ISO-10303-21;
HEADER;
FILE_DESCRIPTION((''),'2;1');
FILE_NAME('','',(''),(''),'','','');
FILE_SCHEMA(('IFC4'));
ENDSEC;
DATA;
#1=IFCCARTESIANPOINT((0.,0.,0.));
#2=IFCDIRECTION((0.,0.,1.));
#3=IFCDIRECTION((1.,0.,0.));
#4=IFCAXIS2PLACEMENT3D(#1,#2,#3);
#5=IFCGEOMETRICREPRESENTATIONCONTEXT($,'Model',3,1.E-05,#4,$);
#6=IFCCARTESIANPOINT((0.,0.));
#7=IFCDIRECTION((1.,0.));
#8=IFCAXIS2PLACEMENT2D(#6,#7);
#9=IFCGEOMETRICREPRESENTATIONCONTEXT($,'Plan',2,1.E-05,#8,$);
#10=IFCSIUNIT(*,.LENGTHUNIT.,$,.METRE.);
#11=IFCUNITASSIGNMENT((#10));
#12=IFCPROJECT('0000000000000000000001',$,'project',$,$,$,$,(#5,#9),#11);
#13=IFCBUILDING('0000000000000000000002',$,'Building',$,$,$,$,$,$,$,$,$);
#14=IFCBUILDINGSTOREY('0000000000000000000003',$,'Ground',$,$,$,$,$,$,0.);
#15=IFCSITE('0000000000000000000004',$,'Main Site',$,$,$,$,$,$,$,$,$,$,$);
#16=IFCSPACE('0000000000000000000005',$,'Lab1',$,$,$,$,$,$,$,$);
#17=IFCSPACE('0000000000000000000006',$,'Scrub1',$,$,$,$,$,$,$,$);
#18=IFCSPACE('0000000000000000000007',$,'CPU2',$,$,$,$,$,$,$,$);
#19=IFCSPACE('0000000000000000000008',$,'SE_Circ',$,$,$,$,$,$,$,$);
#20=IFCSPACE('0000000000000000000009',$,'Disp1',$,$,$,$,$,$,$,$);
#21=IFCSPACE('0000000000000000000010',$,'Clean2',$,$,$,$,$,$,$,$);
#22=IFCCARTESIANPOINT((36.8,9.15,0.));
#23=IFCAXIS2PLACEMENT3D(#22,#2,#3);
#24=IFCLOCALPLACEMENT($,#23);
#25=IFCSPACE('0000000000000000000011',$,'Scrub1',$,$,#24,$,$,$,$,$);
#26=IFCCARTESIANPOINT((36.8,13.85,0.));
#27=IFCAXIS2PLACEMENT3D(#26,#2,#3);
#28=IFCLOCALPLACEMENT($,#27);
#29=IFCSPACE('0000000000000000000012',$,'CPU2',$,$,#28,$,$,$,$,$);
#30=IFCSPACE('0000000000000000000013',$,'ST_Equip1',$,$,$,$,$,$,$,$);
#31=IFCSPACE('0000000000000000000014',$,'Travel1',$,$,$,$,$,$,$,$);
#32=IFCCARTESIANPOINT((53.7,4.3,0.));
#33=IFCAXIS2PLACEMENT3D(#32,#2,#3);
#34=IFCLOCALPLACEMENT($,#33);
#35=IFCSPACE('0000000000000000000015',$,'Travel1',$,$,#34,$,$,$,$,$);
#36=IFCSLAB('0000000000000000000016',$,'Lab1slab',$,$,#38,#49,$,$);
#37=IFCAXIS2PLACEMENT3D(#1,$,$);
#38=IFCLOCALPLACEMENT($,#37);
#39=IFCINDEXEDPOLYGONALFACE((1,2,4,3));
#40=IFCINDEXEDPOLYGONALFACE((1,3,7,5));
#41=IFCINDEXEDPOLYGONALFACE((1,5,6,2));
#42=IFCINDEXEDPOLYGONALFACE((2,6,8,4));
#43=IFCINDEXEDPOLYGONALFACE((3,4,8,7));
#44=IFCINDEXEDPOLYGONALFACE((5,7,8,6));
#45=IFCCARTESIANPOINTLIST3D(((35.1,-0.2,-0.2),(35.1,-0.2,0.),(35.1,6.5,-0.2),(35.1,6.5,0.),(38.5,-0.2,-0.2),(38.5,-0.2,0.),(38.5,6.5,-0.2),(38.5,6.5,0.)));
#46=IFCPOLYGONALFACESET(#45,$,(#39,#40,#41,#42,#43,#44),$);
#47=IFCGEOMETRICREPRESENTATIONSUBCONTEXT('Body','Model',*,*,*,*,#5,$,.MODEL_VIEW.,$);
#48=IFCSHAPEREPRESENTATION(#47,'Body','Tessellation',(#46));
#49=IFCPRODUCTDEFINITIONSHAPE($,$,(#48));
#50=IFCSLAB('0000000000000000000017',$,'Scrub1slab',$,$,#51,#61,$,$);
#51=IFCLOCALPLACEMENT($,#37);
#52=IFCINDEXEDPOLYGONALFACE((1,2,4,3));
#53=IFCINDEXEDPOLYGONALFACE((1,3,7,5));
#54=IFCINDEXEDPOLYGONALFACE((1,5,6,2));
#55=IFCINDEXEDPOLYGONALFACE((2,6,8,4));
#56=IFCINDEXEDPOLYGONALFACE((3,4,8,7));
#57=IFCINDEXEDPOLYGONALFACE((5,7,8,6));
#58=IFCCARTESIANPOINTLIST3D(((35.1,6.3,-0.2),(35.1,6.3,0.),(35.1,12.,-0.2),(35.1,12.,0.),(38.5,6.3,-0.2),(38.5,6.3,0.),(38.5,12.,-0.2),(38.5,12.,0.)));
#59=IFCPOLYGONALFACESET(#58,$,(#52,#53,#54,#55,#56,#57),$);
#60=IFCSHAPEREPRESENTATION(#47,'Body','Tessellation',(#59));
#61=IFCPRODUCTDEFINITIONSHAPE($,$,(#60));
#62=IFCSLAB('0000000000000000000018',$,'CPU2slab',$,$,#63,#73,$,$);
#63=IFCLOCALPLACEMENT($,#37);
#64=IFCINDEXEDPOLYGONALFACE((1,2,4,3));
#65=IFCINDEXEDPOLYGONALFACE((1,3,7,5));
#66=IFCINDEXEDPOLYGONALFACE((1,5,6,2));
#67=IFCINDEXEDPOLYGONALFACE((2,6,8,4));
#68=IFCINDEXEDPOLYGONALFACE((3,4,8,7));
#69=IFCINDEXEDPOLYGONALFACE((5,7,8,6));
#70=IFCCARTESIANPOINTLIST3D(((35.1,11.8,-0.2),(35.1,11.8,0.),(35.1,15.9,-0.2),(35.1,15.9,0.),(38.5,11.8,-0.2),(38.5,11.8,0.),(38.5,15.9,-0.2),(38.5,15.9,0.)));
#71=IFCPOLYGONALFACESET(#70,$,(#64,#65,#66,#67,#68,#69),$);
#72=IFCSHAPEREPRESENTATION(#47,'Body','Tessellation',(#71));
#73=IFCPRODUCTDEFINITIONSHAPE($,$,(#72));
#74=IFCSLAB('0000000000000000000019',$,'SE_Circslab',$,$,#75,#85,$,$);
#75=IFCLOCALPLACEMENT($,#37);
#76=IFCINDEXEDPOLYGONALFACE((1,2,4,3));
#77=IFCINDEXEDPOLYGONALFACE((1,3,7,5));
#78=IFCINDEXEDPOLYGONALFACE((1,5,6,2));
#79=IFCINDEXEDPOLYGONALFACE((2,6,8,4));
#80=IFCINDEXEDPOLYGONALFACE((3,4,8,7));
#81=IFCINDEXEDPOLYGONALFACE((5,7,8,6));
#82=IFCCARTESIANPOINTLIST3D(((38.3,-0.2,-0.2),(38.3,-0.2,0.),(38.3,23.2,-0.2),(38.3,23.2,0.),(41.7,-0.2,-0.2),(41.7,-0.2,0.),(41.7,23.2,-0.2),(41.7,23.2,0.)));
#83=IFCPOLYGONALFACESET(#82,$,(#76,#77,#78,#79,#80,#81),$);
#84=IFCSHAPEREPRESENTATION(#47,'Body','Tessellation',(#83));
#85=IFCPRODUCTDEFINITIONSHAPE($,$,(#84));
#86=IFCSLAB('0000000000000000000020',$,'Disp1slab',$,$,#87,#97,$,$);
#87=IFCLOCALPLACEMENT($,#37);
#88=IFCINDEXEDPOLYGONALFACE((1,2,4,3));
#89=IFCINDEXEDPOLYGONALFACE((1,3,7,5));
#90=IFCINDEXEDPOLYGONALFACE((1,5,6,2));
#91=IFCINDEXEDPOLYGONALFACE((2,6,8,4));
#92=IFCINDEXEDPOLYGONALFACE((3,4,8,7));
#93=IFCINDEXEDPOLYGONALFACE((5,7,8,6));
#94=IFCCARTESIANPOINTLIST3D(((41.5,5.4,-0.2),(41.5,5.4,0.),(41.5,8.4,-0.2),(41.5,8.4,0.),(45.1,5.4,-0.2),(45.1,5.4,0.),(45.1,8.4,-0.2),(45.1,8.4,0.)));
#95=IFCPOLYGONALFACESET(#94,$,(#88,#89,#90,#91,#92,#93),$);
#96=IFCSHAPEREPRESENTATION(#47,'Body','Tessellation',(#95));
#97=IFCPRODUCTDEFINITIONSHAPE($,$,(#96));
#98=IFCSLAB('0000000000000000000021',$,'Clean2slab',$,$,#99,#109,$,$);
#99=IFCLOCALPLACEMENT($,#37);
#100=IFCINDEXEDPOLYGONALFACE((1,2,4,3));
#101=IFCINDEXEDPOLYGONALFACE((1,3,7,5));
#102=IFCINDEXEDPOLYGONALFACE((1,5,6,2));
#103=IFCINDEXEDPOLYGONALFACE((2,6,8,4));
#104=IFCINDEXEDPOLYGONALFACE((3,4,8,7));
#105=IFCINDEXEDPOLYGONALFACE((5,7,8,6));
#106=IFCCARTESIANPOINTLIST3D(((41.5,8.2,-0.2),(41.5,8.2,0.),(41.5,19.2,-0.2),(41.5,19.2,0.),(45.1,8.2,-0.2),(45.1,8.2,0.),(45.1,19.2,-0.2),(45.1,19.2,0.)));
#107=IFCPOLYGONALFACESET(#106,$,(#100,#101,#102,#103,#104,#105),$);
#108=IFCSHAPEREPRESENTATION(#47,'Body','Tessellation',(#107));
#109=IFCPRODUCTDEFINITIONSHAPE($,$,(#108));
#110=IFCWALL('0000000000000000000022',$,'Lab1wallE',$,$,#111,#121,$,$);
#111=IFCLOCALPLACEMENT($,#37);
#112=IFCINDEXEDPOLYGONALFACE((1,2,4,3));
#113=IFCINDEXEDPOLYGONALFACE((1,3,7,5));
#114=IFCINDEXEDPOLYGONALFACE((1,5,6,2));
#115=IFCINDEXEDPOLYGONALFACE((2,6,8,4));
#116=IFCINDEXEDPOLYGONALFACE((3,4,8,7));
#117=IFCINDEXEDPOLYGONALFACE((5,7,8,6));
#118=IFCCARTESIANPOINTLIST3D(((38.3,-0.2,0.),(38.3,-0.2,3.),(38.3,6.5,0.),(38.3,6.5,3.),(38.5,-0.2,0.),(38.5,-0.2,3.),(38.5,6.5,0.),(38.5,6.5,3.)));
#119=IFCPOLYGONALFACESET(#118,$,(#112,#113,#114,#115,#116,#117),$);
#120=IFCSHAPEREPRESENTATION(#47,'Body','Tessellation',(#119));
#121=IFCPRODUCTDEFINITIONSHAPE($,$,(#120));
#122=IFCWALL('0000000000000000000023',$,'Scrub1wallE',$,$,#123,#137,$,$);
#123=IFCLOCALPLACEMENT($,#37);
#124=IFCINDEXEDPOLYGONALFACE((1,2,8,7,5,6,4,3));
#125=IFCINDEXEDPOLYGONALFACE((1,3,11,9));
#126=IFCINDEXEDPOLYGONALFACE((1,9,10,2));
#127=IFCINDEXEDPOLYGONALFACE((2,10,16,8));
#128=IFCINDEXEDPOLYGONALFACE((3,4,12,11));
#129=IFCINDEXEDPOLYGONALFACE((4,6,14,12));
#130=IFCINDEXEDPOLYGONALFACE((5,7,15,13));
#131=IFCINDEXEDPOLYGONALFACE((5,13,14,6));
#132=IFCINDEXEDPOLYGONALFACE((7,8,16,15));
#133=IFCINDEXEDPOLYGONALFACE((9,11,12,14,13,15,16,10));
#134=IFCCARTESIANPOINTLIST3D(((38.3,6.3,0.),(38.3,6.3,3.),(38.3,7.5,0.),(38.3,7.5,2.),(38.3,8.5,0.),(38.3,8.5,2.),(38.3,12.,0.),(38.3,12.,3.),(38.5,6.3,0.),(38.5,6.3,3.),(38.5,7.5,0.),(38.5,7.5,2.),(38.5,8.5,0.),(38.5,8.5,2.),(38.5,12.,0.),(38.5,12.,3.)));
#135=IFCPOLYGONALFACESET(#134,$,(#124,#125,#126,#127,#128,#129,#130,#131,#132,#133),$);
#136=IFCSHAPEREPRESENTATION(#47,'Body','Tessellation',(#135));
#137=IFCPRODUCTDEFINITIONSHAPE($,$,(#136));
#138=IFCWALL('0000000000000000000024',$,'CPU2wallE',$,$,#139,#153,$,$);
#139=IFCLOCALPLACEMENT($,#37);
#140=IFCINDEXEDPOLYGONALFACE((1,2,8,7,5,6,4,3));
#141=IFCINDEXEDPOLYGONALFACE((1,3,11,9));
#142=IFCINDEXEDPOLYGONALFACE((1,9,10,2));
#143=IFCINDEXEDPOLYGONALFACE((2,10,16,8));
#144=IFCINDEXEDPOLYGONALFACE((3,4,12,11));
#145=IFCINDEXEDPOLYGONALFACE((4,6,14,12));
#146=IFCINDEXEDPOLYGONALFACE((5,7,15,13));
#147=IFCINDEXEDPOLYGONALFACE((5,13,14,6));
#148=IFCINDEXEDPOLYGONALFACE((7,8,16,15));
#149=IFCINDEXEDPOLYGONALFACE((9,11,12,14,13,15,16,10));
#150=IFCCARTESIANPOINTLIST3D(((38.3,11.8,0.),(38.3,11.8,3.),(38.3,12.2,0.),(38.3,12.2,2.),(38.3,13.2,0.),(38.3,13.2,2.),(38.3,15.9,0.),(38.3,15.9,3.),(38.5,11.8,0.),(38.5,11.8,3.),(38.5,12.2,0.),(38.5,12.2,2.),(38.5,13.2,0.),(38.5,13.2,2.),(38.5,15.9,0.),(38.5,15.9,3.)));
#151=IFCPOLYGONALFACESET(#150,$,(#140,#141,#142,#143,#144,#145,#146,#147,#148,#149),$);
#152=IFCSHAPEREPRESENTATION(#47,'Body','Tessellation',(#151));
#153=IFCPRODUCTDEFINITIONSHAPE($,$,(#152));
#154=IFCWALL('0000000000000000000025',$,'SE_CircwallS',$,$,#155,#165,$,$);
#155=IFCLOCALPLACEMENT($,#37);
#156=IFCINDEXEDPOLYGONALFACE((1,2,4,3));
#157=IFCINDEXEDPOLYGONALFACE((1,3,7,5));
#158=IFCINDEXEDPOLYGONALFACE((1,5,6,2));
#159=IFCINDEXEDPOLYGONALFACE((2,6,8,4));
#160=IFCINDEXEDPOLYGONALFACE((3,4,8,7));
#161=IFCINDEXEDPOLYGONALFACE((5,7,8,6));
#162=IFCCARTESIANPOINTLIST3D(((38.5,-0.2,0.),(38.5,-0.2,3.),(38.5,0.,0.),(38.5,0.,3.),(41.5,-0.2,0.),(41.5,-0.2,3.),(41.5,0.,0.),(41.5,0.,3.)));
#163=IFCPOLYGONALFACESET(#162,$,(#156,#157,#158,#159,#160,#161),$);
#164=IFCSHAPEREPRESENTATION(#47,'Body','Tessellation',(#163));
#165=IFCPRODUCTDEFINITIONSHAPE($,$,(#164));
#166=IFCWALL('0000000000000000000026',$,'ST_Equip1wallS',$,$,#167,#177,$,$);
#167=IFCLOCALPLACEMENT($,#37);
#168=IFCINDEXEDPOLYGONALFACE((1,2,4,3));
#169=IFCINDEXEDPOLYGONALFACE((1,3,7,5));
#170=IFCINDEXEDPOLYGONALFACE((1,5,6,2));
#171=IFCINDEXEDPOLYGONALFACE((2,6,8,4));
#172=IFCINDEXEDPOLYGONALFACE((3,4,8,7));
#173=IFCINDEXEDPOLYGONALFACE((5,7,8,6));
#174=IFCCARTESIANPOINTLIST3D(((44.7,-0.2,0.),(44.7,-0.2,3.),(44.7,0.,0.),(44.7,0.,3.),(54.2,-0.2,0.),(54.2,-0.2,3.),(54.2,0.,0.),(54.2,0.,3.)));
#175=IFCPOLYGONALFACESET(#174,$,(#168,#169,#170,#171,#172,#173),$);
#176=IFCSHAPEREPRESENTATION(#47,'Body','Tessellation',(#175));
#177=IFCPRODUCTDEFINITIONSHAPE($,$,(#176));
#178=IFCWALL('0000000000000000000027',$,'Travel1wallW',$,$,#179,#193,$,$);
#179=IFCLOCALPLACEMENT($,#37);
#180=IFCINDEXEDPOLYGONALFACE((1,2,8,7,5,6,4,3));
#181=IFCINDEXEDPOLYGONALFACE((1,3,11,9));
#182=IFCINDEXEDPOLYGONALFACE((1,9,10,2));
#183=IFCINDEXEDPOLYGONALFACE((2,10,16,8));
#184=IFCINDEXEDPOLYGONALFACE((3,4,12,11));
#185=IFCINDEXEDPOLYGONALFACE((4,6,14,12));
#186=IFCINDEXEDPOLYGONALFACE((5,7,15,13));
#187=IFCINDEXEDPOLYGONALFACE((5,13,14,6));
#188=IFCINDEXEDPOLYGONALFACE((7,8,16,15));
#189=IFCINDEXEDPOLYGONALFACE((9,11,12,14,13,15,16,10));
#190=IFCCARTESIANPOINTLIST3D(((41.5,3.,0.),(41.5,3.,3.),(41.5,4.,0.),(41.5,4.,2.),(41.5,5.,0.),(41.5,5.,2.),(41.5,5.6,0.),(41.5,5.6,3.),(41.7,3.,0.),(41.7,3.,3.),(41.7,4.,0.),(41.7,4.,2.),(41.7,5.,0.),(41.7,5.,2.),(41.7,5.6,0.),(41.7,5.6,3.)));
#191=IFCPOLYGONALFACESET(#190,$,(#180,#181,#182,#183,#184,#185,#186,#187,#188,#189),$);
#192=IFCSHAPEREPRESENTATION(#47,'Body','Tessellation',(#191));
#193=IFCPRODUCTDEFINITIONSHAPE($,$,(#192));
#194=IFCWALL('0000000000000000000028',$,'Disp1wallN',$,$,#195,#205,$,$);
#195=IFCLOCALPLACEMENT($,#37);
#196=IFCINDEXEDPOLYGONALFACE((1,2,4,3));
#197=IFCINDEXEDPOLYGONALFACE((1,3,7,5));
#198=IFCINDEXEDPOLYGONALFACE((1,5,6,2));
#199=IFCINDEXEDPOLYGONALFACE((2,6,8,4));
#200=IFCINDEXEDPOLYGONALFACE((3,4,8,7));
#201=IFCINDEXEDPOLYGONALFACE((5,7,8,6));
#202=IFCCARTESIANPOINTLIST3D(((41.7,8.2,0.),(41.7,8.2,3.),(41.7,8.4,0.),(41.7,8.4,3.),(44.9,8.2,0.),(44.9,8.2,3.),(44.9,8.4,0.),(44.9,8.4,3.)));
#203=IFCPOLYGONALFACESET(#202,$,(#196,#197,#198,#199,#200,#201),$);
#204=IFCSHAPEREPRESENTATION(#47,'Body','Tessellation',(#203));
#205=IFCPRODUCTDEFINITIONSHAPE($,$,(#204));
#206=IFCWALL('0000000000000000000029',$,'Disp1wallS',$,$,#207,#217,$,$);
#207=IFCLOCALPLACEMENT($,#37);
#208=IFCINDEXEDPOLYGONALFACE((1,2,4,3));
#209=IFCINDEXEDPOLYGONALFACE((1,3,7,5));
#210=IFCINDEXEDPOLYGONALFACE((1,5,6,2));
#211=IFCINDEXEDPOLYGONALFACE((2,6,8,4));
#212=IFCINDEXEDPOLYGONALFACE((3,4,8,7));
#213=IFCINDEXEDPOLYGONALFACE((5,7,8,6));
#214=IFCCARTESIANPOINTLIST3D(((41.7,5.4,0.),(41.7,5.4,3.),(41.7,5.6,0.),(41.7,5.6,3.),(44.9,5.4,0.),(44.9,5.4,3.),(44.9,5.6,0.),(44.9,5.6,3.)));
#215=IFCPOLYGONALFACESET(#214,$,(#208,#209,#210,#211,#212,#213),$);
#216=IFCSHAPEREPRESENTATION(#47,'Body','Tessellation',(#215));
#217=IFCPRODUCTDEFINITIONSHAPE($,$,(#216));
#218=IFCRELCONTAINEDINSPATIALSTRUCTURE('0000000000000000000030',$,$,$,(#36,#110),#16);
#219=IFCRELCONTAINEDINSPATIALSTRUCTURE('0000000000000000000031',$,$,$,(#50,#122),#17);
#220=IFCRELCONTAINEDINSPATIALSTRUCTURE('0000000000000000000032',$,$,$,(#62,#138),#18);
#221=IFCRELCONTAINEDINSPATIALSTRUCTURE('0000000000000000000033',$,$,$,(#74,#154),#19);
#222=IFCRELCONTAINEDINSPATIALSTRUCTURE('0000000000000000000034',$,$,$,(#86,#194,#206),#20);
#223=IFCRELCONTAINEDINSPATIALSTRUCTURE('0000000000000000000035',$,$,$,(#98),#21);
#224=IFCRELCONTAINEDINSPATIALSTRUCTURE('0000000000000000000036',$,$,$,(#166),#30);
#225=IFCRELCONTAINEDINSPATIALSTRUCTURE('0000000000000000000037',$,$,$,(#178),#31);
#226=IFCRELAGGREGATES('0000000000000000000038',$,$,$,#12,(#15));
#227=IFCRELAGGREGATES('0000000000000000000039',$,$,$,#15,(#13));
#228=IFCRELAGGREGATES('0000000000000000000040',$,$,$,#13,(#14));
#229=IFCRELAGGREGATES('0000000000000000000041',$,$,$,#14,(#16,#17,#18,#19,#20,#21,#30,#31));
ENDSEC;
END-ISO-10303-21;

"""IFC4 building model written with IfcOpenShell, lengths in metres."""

from ifc_helpers import new_model, si_unit, frame, origin_with_axes, origin_2d_with_axis, place, context, subcontext, project, spatial, indexed_curve, rectangle, outline, extrude, element, save


model = new_model("IFC4")

# Units and contexts
model_context = context("Model", 3, precision=1e-05, world=origin_with_axes())
plan_context = context("Plan", 2, precision=1e-05, world=origin_2d_with_axis())
body_context = subcontext(model_context, "Body", "Model", "MODEL_VIEW")
ifc_project = project(units=[si_unit("LENGTHUNIT", "METRE")], contexts=[model_context, plan_context])

# Site, building, storey, space
site = spatial("IfcSite", under=ifc_project, Name="Main Site")
building = spatial("IfcBuilding", under=site, Name="Building")
storey = spatial("IfcBuildingStorey", under=building, Name="Ground", Elevation=0.0)
space_1 = spatial("IfcSpace", under=storey, Name="Lab1")

# Slab
slab_1_placement = place(None, frame((36.8, 3.15, -0.2), z_axis=(0.0, 0.0, 1.0), x_axis=(1.0, 0.0, 0.0)))
element("IfcSlab", 1, at=slab_1_placement, inside=space_1, Name="Lab1slab", context=body_context, shape_type="SweptSolid", body=[
    extrude(rectangle(XDim=3.4, YDim=6.7), origin_with_axes(), (0.0, 0.0, 1.0), 0.2),
])

# Shared definitions
space_2 = spatial("IfcSpace", under=storey, Name="Scrub1")

# Slab
slab_2_placement = place(None, frame((36.8, 9.15, -0.2), z_axis=(0.0, 0.0, 1.0), x_axis=(1.0, 0.0, 0.0)))
element("IfcSlab", 2, at=slab_2_placement, inside=space_2, Name="Scrub1slab", context=body_context, shape_type="SweptSolid", body=[
    extrude(rectangle(XDim=3.4, YDim=5.7), origin_with_axes(), (0.0, 0.0, 1.0), 0.2),
])

# Shared definitions
space_3 = spatial("IfcSpace", under=storey, Name="CPU2")

# Slab
slab_3_placement = place(None, frame((36.8, 13.85, -0.2), z_axis=(0.0, 0.0, 1.0), x_axis=(1.0, 0.0, 0.0)))
element("IfcSlab", 3, at=slab_3_placement, inside=space_3, Name="CPU2slab", context=body_context, shape_type="SweptSolid", body=[
    extrude(rectangle(XDim=3.4, YDim=4.1), origin_with_axes(), (0.0, 0.0, 1.0), 0.2),
])

# Shared definitions
space_4 = spatial("IfcSpace", under=storey, Name="SE_Circ")

# Slab
slab_4_placement = place(None, frame((40.0, 11.5, -0.2), z_axis=(0.0, 0.0, 1.0), x_axis=(1.0, 0.0, 0.0)))
element("IfcSlab", 4, at=slab_4_placement, inside=space_4, Name="SE_Circslab", context=body_context, shape_type="SweptSolid", body=[
    extrude(rectangle(XDim=3.4, YDim=23.4), origin_with_axes(), (0.0, 0.0, 1.0), 0.2),
])

# Shared definitions
space_5 = spatial("IfcSpace", under=storey, Name="Disp1")

# Slab
slab_5_placement = place(None, frame((43.3, 6.9, -0.2), z_axis=(0.0, 0.0, 1.0), x_axis=(1.0, 0.0, 0.0)))
element("IfcSlab", 5, at=slab_5_placement, inside=space_5, Name="Disp1slab", context=body_context, shape_type="SweptSolid", body=[
    extrude(rectangle(XDim=3.6, YDim=3.0), origin_with_axes(), (0.0, 0.0, 1.0), 0.2),
])

# Shared definitions
space_6 = spatial("IfcSpace", under=storey, Name="Clean2")

# Slab
slab_6_placement = place(None, frame((43.3, 13.7, -0.2), z_axis=(0.0, 0.0, 1.0), x_axis=(1.0, 0.0, 0.0)))
element("IfcSlab", 6, at=slab_6_placement, inside=space_6, Name="Clean2slab", context=body_context, shape_type="SweptSolid", body=[
    extrude(rectangle(XDim=3.6, YDim=11.0), origin_with_axes(), (0.0, 0.0, 1.0), 0.2),
])

# Walls
wall_1_placement = place(None, frame((38.5, -0.2, 0.0), z_axis=(0.0, 0.0, 1.0), x_axis=(0.0, 1.0, 0.0)))
element("IfcWall", 7, at=wall_1_placement, inside=space_1, Name="Lab1wallE", context=body_context, shape_type="SweptSolid", body=[
    extrude(outline(indexed_curve([(0.0, 0.0), (0.0, 0.2), (6.7, 0.2), (6.7, 0.0), (0.0, 0.0)], self_intersect=False)), origin_with_axes(), (0.0, 0.0, 1.0), 3.0),
])
wall_2_placement = place(None, frame((38.5, 6.3, 0.0), z_axis=(0.0, 0.0, 1.0), x_axis=(0.0, 1.0, 0.0)))
wall_2 = element("IfcWall", 8, at=wall_2_placement, inside=space_2, Name="Scrub1wallE", context=body_context, shape_type="SweptSolid", body=[
    extrude(outline(indexed_curve([(0.0, 0.0), (0.0, 0.2), (5.7, 0.2), (5.7, 0.0), (0.0, 0.0)], self_intersect=False)), origin_with_axes(), (0.0, 0.0, 1.0), 3.0),
])

# Shared definitions
space_7_placement = place(None, frame((36.8, 9.15, 0.0), z_axis=(0.0, 0.0, 1.0), x_axis=(1.0, 0.0, 0.0)))
space_7 = spatial("IfcSpace", at=space_7_placement, Name="Scrub1")

# Opening
opening_1_placement = place(wall_2_placement, frame((1.2, 0.0, 0.0), z_axis=(0.0, 0.0, 1.0), x_axis=(1.0, 0.0, 0.0)))
element("IfcOpeningElement", 9, at=opening_1_placement, inside=space_7, cuts=wall_2, context=body_context, shape_type="SweptSolid", body=[
    extrude(outline(indexed_curve([(0.0, 0.0), (0.0, 0.4), (1.0, 0.4), (1.0, 0.0), (0.0, 0.0)], self_intersect=False)), origin_with_axes(), (0.0, 0.0, 1.0), 2.0),
])

# Wall
wall_3_placement = place(None, frame((38.5, 11.8, 0.0), z_axis=(0.0, 0.0, 1.0), x_axis=(0.0, 1.0, 0.0)))
wall_3 = element("IfcWall", 10, at=wall_3_placement, inside=space_3, Name="CPU2wallE", context=body_context, shape_type="SweptSolid", body=[
    extrude(outline(indexed_curve([(0.0, 0.0), (0.0, 0.2), (4.1, 0.2), (4.1, 0.0), (0.0, 0.0)], self_intersect=False)), origin_with_axes(), (0.0, 0.0, 1.0), 3.0),
])

# Shared definitions
space_8_placement = place(None, frame((36.8, 13.85, 0.0), z_axis=(0.0, 0.0, 1.0), x_axis=(1.0, 0.0, 0.0)))
space_8 = spatial("IfcSpace", at=space_8_placement, Name="CPU2")

# Opening
opening_2_placement = place(wall_3_placement, frame((0.4, 0.0, 0.0), z_axis=(0.0, 0.0, 1.0), x_axis=(1.0, 0.0, 0.0)))
element("IfcOpeningElement", 11, at=opening_2_placement, inside=space_8, cuts=wall_3, context=body_context, shape_type="SweptSolid", body=[
    extrude(outline(indexed_curve([(0.0, 0.0), (0.0, 0.4), (1.0, 0.4), (1.0, 0.0), (0.0, 0.0)], self_intersect=False)), origin_with_axes(), (0.0, 0.0, 1.0), 2.0),
])

# Wall
wall_4_placement = place(None, frame((38.5, -0.2, 0.0), z_axis=(0.0, 0.0, 1.0), x_axis=(1.0, 0.0, 0.0)))
element("IfcWall", 12, at=wall_4_placement, inside=space_4, Name="SE_CircwallS", context=body_context, shape_type="SweptSolid", body=[
    extrude(outline(indexed_curve([(0.0, 0.0), (0.0, 0.2), (3.0, 0.2), (3.0, 0.0), (0.0, 0.0)], self_intersect=False)), origin_with_axes(), (0.0, 0.0, 1.0), 3.0),
])

# Shared definitions
space_9 = spatial("IfcSpace", under=storey, Name="ST_Equip1")

# Wall
wall_5_placement = place(None, frame((44.7, -0.2, 0.0), z_axis=(0.0, 0.0, 1.0), x_axis=(1.0, 0.0, 0.0)))
element("IfcWall", 13, at=wall_5_placement, inside=space_9, Name="ST_Equip1wallS", context=body_context, shape_type="SweptSolid", body=[
    extrude(outline(indexed_curve([(0.0, 0.0), (0.0, 0.2), (9.5, 0.2), (9.5, 0.0), (0.0, 0.0)], self_intersect=False)), origin_with_axes(), (0.0, 0.0, 1.0), 3.0),
])

# Shared definitions
space_10 = spatial("IfcSpace", under=storey, Name="Travel1")

# Shared definitions
space_11_placement = place(None, frame((53.7, 4.3, 0.0), z_axis=(0.0, 0.0, 1.0), x_axis=(1.0, 0.0, 0.0)))
space_11 = spatial("IfcSpace", at=space_11_placement, Name="Travel1")

# Wall, opening
wall_6_placement = place(None, frame((41.7, 3.0, 0.0), z_axis=(0.0, 0.0, 1.0), x_axis=(0.0, 1.0, 0.0)))
wall_6 = element("IfcWall", 14, at=wall_6_placement, inside=space_10, Name="Travel1wallW", context=body_context, shape_type="SweptSolid", body=[
    extrude(outline(indexed_curve([(0.0, 0.0), (0.0, 0.2), (2.6, 0.2), (2.6, 0.0), (0.0, 0.0)], self_intersect=False)), origin_with_axes(), (0.0, 0.0, 1.0), 3.0),
])
opening_3_placement = place(wall_6_placement, frame((1.0, 0.0, 0.0), z_axis=(0.0, 0.0, 1.0), x_axis=(1.0, 0.0, 0.0)))
element("IfcOpeningElement", 15, at=opening_3_placement, inside=space_11, cuts=wall_6, context=body_context, shape_type="SweptSolid", body=[
    extrude(outline(indexed_curve([(0.0, 0.0), (0.0, 0.4), (1.0, 0.4), (1.0, 0.0), (0.0, 0.0)], self_intersect=False)), origin_with_axes(), (0.0, 0.0, 1.0), 2.0),
])

# Walls
for number, where, z_axis, x_axis, name in (
    (16, (41.7, 8.2, 0.0), (0.0, 0.0, 1.0), (1.0, 0.0, 0.0), "Disp1wallN"),
    (17, (41.7, 5.4, 0.0), (0.0, 0.0, 1.0), (1.0, 0.0, 0.0), "Disp1wallS"),
):
    element("IfcWall", number, at=place(None, frame(where, z_axis=z_axis, x_axis=x_axis)), inside=space_5, Name=name, context=body_context, shape_type="SweptSolid", body=[
        extrude(outline(indexed_curve([(0.0, 0.0), (0.0, 0.2), (3.2, 0.2), (3.2, 0.0), (0.0, 0.0)], self_intersect=False)), origin_with_axes(), (0.0, 0.0, 1.0), 3.0),
    ])

save(model, "model.ifc")
